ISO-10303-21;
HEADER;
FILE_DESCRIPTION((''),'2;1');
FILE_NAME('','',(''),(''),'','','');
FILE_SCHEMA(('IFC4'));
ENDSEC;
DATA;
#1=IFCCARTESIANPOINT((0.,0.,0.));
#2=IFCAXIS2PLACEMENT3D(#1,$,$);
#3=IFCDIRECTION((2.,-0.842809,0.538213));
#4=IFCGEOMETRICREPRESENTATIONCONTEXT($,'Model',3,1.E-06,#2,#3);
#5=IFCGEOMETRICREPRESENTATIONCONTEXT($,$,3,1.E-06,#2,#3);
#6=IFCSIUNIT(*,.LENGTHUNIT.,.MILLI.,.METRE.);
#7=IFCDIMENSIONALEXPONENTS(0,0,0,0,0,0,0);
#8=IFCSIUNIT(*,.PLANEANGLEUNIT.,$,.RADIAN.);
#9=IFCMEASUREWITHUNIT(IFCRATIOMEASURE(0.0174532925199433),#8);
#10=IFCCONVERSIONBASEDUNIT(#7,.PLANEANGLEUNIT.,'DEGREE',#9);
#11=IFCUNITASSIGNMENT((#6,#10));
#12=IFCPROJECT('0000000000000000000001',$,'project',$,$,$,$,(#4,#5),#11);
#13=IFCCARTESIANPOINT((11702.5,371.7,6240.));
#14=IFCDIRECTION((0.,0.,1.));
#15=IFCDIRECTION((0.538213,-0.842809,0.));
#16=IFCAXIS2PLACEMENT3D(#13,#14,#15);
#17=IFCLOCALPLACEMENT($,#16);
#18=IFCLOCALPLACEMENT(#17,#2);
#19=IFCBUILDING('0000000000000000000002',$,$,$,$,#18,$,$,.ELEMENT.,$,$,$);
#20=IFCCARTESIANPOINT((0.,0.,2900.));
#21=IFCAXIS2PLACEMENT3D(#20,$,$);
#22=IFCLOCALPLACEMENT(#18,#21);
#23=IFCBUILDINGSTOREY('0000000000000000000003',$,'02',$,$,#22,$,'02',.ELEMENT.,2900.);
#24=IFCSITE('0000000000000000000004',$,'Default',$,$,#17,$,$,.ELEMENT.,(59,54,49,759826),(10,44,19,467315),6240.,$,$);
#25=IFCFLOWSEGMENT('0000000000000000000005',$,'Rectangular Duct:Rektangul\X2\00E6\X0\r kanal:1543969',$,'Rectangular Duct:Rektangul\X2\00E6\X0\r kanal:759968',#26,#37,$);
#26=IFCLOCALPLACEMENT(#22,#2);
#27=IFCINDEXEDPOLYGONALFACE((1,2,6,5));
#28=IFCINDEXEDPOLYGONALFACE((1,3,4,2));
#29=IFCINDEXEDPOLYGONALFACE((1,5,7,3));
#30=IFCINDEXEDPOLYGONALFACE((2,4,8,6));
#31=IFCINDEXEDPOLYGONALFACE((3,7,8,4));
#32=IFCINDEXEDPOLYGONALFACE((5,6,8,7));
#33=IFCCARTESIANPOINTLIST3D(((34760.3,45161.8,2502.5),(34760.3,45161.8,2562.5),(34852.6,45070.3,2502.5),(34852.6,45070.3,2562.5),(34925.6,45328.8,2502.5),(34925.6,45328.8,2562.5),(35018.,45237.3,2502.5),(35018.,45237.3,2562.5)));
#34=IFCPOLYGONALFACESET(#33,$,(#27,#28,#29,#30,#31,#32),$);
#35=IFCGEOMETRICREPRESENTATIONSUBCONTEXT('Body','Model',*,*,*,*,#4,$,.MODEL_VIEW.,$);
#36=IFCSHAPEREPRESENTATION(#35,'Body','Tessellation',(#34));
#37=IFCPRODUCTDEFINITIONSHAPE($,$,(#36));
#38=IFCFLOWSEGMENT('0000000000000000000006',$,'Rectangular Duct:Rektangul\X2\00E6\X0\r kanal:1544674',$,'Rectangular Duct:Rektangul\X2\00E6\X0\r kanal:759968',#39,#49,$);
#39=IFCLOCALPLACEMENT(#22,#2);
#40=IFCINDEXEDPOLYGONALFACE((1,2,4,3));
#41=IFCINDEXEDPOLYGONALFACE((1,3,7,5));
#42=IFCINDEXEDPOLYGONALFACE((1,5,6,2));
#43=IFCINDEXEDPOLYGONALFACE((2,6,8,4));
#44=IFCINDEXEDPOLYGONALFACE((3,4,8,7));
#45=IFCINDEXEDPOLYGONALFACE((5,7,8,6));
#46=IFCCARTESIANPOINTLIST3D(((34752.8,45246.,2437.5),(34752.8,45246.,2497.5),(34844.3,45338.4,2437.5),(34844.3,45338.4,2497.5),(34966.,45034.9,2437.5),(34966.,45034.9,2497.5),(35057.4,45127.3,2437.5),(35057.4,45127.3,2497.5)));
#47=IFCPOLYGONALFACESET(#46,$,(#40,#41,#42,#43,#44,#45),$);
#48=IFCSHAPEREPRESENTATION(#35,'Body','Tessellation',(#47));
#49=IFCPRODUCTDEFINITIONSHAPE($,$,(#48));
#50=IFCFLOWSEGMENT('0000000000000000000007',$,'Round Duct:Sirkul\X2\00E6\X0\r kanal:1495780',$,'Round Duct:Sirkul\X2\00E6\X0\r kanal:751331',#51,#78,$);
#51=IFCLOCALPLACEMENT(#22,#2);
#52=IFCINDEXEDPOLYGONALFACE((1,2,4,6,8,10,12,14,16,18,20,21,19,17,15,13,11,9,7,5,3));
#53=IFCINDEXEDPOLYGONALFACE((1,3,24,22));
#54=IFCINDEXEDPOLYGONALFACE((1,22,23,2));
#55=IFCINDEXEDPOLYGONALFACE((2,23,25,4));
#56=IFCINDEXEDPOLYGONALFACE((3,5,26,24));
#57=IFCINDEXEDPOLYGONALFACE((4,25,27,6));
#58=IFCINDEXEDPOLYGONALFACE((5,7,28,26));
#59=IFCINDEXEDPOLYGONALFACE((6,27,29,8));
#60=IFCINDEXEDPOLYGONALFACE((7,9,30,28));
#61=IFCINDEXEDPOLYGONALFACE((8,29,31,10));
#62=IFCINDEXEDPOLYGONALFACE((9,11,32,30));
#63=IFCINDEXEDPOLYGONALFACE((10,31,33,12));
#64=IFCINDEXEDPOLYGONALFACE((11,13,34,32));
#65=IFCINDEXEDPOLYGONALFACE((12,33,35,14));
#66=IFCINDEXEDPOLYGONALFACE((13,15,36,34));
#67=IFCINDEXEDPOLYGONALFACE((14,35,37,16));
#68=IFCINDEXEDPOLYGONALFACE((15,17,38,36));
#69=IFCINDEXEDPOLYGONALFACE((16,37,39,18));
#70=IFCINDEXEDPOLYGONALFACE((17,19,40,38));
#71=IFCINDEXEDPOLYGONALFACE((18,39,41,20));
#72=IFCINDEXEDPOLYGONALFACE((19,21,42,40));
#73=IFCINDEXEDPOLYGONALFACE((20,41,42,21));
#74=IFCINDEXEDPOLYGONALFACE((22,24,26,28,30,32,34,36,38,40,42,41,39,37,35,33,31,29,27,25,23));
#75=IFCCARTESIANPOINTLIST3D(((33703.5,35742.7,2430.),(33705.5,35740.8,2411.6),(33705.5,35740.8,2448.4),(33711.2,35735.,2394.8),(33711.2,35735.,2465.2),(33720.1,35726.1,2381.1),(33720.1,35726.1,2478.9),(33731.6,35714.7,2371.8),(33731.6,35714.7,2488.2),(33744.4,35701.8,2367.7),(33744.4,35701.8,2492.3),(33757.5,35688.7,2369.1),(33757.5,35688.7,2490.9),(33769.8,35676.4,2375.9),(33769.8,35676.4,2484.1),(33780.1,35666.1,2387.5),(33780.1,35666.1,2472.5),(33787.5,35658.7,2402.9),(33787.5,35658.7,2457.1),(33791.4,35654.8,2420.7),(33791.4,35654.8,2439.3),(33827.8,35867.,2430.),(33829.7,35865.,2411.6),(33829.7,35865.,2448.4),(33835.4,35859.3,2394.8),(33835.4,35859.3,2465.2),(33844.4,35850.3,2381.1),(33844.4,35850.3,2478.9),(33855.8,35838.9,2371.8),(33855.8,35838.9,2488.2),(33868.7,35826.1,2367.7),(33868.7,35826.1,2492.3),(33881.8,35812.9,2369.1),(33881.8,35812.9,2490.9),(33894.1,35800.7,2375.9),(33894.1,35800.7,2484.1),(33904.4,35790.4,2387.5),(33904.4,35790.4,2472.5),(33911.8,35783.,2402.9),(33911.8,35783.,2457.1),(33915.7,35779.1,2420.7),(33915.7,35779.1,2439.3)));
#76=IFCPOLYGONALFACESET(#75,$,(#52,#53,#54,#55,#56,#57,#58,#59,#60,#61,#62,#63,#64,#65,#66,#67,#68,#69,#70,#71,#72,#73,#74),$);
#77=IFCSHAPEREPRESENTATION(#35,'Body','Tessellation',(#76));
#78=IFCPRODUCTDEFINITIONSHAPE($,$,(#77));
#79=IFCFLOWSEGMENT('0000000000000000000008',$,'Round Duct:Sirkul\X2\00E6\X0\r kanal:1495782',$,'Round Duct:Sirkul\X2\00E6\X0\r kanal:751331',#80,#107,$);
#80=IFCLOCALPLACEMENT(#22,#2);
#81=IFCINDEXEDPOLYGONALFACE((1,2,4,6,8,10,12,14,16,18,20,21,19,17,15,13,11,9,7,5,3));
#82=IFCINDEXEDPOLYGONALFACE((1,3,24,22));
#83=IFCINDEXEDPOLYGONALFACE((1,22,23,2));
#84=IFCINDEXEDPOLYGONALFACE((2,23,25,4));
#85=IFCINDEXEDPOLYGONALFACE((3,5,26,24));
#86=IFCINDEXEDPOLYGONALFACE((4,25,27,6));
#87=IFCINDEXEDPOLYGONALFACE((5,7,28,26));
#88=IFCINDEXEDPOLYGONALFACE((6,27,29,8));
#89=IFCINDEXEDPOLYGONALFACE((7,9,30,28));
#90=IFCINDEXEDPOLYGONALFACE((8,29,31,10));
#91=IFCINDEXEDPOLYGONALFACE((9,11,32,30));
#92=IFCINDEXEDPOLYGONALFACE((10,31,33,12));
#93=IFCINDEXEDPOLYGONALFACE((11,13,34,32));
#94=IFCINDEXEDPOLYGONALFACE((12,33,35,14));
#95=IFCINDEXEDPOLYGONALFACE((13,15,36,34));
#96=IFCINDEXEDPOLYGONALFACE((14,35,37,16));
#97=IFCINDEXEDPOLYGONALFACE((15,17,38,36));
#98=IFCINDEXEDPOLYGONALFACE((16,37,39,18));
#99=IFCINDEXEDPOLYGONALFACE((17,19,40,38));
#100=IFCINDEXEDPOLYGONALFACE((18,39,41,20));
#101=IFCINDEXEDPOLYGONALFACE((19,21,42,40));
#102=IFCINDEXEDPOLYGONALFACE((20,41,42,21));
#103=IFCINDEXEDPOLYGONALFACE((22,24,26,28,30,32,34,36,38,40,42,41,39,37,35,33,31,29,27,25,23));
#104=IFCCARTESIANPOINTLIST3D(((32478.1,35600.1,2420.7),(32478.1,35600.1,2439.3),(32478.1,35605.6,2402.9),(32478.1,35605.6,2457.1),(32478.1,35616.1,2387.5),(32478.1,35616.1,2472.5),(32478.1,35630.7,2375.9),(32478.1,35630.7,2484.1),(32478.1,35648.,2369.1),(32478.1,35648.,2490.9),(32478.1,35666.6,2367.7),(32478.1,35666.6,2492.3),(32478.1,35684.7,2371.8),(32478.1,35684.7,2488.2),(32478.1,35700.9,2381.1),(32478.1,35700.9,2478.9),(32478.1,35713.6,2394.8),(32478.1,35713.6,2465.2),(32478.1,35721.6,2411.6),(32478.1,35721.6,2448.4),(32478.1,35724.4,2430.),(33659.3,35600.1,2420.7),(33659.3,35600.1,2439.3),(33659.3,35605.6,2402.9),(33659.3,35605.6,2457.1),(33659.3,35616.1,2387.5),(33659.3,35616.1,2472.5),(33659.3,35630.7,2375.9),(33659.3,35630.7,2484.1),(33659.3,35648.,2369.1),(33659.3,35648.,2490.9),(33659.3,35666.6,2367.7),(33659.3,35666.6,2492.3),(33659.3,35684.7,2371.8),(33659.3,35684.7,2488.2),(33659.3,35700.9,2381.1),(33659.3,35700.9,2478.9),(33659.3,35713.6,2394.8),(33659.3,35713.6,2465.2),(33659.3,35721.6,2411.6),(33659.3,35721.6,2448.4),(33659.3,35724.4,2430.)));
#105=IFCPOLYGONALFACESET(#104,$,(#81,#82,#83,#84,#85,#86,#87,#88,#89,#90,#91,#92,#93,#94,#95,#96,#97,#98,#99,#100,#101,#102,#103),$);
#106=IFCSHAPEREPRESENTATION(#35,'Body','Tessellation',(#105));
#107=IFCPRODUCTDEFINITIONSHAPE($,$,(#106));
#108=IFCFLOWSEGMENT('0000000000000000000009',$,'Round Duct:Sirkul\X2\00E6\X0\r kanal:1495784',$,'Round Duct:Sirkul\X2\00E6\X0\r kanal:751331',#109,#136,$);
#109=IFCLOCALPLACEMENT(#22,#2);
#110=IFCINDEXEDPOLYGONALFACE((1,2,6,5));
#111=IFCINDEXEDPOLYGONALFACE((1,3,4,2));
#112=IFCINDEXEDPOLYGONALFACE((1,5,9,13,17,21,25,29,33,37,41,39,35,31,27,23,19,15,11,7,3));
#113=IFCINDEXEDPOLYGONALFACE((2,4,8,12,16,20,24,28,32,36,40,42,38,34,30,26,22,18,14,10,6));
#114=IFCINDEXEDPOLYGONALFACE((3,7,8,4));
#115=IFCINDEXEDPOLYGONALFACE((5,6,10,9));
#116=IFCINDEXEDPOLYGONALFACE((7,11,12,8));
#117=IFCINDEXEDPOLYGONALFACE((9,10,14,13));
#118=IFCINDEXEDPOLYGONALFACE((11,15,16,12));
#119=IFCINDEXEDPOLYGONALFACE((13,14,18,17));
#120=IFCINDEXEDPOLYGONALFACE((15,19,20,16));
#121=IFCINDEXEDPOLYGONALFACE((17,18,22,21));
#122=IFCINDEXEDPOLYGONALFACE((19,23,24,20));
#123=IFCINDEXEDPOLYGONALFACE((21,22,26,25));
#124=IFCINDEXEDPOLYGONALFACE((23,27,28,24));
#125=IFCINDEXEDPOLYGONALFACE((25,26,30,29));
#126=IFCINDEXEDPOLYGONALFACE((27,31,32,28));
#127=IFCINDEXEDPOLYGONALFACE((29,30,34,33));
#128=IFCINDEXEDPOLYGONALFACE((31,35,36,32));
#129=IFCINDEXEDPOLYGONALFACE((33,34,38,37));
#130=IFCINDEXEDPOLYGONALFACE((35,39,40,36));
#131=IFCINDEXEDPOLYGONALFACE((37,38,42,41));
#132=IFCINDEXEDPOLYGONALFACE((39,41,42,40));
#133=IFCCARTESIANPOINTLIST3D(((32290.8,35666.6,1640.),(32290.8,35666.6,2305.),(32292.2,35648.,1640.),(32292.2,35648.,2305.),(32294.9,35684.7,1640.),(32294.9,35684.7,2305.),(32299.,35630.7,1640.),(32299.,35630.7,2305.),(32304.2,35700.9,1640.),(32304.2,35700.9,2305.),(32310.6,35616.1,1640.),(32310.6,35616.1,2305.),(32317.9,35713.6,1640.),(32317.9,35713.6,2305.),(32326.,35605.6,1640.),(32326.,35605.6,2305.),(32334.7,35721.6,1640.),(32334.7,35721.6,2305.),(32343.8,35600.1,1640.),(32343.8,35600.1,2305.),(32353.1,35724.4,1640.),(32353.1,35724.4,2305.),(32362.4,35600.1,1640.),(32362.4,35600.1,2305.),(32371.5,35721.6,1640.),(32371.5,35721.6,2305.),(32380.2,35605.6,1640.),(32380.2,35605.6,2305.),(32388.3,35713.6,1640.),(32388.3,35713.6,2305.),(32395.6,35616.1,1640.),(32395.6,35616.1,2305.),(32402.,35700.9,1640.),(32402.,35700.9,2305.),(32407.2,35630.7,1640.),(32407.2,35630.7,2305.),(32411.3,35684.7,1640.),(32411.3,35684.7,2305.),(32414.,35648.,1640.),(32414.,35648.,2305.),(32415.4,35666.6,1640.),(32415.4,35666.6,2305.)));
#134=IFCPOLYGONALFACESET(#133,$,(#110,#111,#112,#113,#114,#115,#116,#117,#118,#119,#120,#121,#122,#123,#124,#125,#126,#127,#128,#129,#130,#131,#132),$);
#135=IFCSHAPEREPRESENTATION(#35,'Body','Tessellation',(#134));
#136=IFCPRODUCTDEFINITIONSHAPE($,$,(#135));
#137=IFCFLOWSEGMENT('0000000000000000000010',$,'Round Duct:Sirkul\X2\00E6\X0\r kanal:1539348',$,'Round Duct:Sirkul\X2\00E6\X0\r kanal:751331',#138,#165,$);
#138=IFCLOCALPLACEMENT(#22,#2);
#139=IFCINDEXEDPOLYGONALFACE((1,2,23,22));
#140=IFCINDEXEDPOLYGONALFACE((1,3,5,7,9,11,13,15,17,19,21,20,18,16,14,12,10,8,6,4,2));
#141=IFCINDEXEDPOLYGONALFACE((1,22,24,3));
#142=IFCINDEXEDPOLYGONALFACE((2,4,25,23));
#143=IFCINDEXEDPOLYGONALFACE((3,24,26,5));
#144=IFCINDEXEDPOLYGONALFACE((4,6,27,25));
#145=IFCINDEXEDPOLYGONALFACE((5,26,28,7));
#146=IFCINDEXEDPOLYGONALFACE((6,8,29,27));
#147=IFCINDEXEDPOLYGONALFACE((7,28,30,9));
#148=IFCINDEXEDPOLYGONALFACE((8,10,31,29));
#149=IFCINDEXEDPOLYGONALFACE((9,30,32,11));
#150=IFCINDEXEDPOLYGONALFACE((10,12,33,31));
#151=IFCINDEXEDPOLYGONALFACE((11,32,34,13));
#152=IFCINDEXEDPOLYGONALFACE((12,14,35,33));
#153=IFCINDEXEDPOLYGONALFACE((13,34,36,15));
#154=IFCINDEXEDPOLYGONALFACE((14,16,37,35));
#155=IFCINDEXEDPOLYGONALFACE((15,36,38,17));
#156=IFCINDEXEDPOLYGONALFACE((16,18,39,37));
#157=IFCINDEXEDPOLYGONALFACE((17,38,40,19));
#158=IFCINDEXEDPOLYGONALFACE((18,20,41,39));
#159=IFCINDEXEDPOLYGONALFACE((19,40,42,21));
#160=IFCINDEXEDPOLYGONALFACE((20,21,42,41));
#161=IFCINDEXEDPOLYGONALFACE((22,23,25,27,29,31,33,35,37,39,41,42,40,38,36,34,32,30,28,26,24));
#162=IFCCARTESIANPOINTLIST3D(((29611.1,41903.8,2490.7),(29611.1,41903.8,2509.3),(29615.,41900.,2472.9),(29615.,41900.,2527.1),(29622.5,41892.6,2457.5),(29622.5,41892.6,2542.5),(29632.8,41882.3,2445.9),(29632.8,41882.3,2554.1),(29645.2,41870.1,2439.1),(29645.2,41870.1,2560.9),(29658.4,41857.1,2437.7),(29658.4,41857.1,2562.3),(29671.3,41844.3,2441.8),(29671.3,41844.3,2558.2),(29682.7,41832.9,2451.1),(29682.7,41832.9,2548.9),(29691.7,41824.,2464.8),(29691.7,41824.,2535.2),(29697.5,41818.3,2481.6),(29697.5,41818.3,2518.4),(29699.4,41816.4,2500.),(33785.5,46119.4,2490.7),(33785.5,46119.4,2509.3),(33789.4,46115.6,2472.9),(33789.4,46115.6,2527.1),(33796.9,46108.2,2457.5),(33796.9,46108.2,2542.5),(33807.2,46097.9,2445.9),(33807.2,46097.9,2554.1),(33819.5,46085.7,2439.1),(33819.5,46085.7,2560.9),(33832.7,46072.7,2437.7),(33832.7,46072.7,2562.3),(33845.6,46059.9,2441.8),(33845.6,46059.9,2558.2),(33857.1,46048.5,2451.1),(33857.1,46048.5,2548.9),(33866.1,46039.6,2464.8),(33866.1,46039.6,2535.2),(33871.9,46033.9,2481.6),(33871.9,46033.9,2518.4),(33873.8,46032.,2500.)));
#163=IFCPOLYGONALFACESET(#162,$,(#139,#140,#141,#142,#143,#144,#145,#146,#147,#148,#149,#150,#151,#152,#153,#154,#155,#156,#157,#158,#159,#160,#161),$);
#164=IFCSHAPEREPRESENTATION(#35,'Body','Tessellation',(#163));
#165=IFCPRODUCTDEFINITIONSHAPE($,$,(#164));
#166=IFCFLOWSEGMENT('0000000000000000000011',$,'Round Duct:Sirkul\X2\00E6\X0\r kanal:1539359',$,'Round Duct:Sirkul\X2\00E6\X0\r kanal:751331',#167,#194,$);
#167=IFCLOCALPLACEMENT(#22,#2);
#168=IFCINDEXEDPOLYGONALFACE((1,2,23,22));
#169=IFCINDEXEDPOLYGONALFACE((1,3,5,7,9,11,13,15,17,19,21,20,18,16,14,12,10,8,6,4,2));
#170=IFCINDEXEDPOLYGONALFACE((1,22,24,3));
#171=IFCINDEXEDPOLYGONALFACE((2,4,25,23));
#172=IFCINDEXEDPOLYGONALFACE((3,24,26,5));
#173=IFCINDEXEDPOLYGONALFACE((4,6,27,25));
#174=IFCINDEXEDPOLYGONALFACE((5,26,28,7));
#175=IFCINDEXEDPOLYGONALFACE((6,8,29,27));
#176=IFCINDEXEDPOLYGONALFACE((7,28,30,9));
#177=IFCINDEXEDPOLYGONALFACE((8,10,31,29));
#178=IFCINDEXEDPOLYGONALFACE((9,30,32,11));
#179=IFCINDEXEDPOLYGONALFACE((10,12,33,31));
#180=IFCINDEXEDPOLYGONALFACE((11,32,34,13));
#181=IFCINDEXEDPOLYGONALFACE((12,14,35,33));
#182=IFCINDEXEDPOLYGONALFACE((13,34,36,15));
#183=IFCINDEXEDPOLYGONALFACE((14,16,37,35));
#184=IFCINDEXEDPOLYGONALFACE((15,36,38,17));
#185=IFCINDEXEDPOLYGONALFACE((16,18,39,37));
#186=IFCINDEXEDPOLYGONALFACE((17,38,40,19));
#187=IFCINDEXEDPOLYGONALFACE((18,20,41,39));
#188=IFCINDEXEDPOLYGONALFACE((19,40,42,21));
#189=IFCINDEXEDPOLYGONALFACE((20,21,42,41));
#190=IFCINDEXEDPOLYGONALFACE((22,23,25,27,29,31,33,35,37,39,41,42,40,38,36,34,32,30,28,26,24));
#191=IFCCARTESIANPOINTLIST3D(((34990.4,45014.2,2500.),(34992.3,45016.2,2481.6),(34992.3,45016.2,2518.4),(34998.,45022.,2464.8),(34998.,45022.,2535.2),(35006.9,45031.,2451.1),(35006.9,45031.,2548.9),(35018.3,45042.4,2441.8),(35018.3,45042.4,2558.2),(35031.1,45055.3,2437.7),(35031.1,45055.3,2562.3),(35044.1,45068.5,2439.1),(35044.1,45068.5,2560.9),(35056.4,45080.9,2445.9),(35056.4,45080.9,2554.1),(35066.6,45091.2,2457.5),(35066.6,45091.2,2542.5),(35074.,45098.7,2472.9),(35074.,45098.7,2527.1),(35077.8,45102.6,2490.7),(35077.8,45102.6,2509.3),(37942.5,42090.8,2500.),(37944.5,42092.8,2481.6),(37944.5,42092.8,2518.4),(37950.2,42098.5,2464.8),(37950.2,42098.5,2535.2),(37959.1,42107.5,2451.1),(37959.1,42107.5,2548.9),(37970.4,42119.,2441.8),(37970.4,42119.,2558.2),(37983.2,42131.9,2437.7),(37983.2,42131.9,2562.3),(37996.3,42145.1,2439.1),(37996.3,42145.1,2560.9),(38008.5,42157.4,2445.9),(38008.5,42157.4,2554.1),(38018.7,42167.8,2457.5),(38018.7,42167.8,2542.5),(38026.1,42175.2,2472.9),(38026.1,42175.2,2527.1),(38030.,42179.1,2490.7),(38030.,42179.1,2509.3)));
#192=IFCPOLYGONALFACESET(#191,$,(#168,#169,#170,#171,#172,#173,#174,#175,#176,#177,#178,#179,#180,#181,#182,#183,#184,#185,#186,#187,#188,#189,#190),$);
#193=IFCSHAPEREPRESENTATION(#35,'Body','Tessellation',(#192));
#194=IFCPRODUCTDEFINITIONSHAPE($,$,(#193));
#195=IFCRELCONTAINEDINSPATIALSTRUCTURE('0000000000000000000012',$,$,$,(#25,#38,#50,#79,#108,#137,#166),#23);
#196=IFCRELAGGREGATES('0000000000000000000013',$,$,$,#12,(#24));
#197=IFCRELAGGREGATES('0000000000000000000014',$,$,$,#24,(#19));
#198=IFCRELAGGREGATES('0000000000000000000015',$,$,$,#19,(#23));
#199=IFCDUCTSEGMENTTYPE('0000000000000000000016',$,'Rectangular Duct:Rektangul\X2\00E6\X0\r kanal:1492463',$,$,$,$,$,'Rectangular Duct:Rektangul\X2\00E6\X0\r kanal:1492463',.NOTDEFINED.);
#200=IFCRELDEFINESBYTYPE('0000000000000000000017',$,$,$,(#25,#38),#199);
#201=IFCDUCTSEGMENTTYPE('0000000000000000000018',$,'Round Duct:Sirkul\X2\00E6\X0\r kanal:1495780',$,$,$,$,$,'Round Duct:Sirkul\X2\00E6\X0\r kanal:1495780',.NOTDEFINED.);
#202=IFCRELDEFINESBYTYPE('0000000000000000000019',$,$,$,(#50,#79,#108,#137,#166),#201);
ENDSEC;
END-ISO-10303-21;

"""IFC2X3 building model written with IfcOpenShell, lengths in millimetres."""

from ifc_helpers import new_model, entity, si_unit, converted_unit, direction, frame, frame_2d, origin, origin_2d_with_axis, place, context, subcontext, project, spatial, rectangle, circle, extrude, type_object, element, save


model = new_model("IFC2X3")

# Units and contexts
model_context = context("Model", 3, precision=1e-06, world=origin(), true_north=direction((2.0, -0.842809, 0.538213)))
context_of_model = context(None, 3, precision=1e-06, world=origin(), true_north=direction((2.0, -0.842809, 0.538213)))
body_context = subcontext(model_context, "Body", "Model", "MODEL_VIEW")
ifc_project = project(units=[si_unit("LENGTHUNIT", "METRE", prefix="MILLI"), converted_unit("PLANEANGLEUNIT", "DEGREE", entity("IfcRatioMeasure", 0.0174532925199433), si_unit("PLANEANGLEUNIT", "RADIAN"), dimensions=[0, 0, 0, 0, 0, 0, 0])], contexts=[model_context, context_of_model])

# Site, building, storey
site_placement = place(None, frame((11702.5, 371.7, 6240.0), z_axis=(0.0, 0.0, 1.0), x_axis=(0.538213, -0.842809, 0.0)))
site = spatial("IfcSite", under=ifc_project, at=site_placement, Name="Default", CompositionType="ELEMENT", RefLatitude=(59, 54, 49, 759826), RefLongitude=(10, 44, 19, 467315), RefElevation=6240.0)
building_placement = place(site_placement, origin())
building = spatial("IfcBuilding", under=site, at=building_placement, CompositionType="ELEMENT")
storey_placement = place(building_placement, frame((0.0, 0.0, 2900.0)))
storey = spatial("IfcBuildingStorey", under=building, at=storey_placement, Name="02", LongName="02", CompositionType="ELEMENT", Elevation=2900.0)

# Flow segments
duct_segment_type_1 = type_object("IfcDuctSegmentType", Name="Rectangular Duct:Rektangulær kanal:1492463", ElementType="Rectangular Duct:Rektangulær kanal:1492463", PredefinedType="NOTDEFINED")
flow_segment_1_placement = place(storey_placement, origin())
element("IfcFlowSegment", 1, at=flow_segment_1_placement, inside=storey, type_object=duct_segment_type_1, Name="Rectangular Duct:Rektangulær kanal:1543969", ObjectType="Rectangular Duct:Rektangulær kanal:759968", context=body_context, shape_type="SweptSolid", body=[
    extrude(rectangle(XDim=235.0, YDim=130.0, at=frame_2d((0.0, 0.0), x_axis=(1.0, 0.0))), frame((34889.1, 45199.5, 2502.5), z_axis=(0.0, 0.0, 1.0), x_axis=(0.703643, 0.710554, 0.0)), (0.0, 0.0, 1.0), 60.0),
])
flow_segment_2_placement = place(storey_placement, origin())
element("IfcFlowSegment", 2, at=flow_segment_2_placement, inside=storey, type_object=duct_segment_type_1, Name="Rectangular Duct:Rektangulær kanal:1544674", ObjectType="Rectangular Duct:Rektangulær kanal:759968", context=body_context, shape_type="SweptSolid", body=[
    extrude(rectangle(XDim=300.0, YDim=130.0, at=frame_2d((0.0, 0.0), x_axis=(1.0, 0.0))), frame((34905.1, 45186.6, 2437.5), z_axis=(0.0, 0.0, 1.0), x_axis=(0.710554, -0.703643, 0.0)), (0.0, 0.0, 1.0), 60.0),
])
duct_segment_type_2 = type_object("IfcDuctSegmentType", Name="Round Duct:Sirkulær kanal:1495780", ElementType="Round Duct:Sirkulær kanal:1495780", PredefinedType="NOTDEFINED")
flow_segment_3_placement = place(storey_placement, origin())
element("IfcFlowSegment", 3, at=flow_segment_3_placement, inside=storey, type_object=duct_segment_type_2, Name="Round Duct:Sirkulær kanal:1495780", ObjectType="Round Duct:Sirkulær kanal:751331", context=body_context, shape_type="SweptSolid", body=[
    extrude(circle(Radius=62.5, at=frame_2d((0.0, 0.0), x_axis=(1.0, 0.0))), frame((33747.7, 35698.5, 2430.0), z_axis=(0.707107, 0.707107, 0.0), x_axis=(-0.707107, 0.707107, 0.0)), (0.0, 0.0, 1.0), 175.7),
])
flow_segment_4_placement = place(storey_placement, origin())
element("IfcFlowSegment", 4, at=flow_segment_4_placement, inside=storey, type_object=duct_segment_type_2, Name="Round Duct:Sirkulær kanal:1495782", ObjectType="Round Duct:Sirkulær kanal:751331", context=body_context, shape_type="SweptSolid", body=[
    extrude(circle(Radius=62.5, at=frame_2d((0.0, 0.0), x_axis=(1.0, 0.0))), frame((32478.1, 35661.9, 2430.0), z_axis=(1.0, 0.0, 0.0), x_axis=(0.0, 1.0, 0.0)), (0.0, 0.0, 1.0), 1181.2),
])
flow_segment_5_placement = place(storey_placement, origin())
element("IfcFlowSegment", 5, at=flow_segment_5_placement, inside=storey, type_object=duct_segment_type_2, Name="Round Duct:Sirkulær kanal:1495784", ObjectType="Round Duct:Sirkulær kanal:751331", context=body_context, shape_type="SweptSolid", body=[
    extrude(circle(Radius=62.5, at=frame_2d((0.0, 0.0), x_axis=(1.0, 0.0))), frame((32353.1, 35661.9, 1640.0), z_axis=(0.0, 0.0, 1.0), x_axis=(0.0, 1.0, 0.0)), (0.0, 0.0, 1.0), 665.0),
])
flow_segment_6_placement = place(storey_placement, origin())
element("IfcFlowSegment", 6, at=flow_segment_6_placement, inside=storey, type_object=duct_segment_type_2, Name="Round Duct:Sirkulær kanal:1539348", ObjectType="Round Duct:Sirkulær kanal:751331", context=body_context, shape_type="SweptSolid", body=[
    extrude(circle(Radius=62.5, at=origin_2d_with_axis()), frame((29655.0, 41860.4, 2500.0), z_axis=(0.703625, 0.710572, 0.0), x_axis=(0.710572, -0.703625, 0.0)), (0.0, 0.0, 1.0), 5932.7),
])
flow_segment_7_placement = place(storey_placement, origin())
element("IfcFlowSegment", 7, at=flow_segment_7_placement, inside=storey, type_object=duct_segment_type_2, Name="Round Duct:Sirkulær kanal:1539359", ObjectType="Round Duct:Sirkulær kanal:751331", context=body_context, shape_type="SweptSolid", body=[
    extrude(circle(Radius=62.5, at=origin_2d_with_axis()), frame((35034.4, 45058.6, 2500.0), z_axis=(0.710554, -0.703643, 0.0), x_axis=(-0.703643, -0.710554, 0.0)), (0.0, 0.0, 1.0), 4154.7),
])

save(model, "model.ifc")
